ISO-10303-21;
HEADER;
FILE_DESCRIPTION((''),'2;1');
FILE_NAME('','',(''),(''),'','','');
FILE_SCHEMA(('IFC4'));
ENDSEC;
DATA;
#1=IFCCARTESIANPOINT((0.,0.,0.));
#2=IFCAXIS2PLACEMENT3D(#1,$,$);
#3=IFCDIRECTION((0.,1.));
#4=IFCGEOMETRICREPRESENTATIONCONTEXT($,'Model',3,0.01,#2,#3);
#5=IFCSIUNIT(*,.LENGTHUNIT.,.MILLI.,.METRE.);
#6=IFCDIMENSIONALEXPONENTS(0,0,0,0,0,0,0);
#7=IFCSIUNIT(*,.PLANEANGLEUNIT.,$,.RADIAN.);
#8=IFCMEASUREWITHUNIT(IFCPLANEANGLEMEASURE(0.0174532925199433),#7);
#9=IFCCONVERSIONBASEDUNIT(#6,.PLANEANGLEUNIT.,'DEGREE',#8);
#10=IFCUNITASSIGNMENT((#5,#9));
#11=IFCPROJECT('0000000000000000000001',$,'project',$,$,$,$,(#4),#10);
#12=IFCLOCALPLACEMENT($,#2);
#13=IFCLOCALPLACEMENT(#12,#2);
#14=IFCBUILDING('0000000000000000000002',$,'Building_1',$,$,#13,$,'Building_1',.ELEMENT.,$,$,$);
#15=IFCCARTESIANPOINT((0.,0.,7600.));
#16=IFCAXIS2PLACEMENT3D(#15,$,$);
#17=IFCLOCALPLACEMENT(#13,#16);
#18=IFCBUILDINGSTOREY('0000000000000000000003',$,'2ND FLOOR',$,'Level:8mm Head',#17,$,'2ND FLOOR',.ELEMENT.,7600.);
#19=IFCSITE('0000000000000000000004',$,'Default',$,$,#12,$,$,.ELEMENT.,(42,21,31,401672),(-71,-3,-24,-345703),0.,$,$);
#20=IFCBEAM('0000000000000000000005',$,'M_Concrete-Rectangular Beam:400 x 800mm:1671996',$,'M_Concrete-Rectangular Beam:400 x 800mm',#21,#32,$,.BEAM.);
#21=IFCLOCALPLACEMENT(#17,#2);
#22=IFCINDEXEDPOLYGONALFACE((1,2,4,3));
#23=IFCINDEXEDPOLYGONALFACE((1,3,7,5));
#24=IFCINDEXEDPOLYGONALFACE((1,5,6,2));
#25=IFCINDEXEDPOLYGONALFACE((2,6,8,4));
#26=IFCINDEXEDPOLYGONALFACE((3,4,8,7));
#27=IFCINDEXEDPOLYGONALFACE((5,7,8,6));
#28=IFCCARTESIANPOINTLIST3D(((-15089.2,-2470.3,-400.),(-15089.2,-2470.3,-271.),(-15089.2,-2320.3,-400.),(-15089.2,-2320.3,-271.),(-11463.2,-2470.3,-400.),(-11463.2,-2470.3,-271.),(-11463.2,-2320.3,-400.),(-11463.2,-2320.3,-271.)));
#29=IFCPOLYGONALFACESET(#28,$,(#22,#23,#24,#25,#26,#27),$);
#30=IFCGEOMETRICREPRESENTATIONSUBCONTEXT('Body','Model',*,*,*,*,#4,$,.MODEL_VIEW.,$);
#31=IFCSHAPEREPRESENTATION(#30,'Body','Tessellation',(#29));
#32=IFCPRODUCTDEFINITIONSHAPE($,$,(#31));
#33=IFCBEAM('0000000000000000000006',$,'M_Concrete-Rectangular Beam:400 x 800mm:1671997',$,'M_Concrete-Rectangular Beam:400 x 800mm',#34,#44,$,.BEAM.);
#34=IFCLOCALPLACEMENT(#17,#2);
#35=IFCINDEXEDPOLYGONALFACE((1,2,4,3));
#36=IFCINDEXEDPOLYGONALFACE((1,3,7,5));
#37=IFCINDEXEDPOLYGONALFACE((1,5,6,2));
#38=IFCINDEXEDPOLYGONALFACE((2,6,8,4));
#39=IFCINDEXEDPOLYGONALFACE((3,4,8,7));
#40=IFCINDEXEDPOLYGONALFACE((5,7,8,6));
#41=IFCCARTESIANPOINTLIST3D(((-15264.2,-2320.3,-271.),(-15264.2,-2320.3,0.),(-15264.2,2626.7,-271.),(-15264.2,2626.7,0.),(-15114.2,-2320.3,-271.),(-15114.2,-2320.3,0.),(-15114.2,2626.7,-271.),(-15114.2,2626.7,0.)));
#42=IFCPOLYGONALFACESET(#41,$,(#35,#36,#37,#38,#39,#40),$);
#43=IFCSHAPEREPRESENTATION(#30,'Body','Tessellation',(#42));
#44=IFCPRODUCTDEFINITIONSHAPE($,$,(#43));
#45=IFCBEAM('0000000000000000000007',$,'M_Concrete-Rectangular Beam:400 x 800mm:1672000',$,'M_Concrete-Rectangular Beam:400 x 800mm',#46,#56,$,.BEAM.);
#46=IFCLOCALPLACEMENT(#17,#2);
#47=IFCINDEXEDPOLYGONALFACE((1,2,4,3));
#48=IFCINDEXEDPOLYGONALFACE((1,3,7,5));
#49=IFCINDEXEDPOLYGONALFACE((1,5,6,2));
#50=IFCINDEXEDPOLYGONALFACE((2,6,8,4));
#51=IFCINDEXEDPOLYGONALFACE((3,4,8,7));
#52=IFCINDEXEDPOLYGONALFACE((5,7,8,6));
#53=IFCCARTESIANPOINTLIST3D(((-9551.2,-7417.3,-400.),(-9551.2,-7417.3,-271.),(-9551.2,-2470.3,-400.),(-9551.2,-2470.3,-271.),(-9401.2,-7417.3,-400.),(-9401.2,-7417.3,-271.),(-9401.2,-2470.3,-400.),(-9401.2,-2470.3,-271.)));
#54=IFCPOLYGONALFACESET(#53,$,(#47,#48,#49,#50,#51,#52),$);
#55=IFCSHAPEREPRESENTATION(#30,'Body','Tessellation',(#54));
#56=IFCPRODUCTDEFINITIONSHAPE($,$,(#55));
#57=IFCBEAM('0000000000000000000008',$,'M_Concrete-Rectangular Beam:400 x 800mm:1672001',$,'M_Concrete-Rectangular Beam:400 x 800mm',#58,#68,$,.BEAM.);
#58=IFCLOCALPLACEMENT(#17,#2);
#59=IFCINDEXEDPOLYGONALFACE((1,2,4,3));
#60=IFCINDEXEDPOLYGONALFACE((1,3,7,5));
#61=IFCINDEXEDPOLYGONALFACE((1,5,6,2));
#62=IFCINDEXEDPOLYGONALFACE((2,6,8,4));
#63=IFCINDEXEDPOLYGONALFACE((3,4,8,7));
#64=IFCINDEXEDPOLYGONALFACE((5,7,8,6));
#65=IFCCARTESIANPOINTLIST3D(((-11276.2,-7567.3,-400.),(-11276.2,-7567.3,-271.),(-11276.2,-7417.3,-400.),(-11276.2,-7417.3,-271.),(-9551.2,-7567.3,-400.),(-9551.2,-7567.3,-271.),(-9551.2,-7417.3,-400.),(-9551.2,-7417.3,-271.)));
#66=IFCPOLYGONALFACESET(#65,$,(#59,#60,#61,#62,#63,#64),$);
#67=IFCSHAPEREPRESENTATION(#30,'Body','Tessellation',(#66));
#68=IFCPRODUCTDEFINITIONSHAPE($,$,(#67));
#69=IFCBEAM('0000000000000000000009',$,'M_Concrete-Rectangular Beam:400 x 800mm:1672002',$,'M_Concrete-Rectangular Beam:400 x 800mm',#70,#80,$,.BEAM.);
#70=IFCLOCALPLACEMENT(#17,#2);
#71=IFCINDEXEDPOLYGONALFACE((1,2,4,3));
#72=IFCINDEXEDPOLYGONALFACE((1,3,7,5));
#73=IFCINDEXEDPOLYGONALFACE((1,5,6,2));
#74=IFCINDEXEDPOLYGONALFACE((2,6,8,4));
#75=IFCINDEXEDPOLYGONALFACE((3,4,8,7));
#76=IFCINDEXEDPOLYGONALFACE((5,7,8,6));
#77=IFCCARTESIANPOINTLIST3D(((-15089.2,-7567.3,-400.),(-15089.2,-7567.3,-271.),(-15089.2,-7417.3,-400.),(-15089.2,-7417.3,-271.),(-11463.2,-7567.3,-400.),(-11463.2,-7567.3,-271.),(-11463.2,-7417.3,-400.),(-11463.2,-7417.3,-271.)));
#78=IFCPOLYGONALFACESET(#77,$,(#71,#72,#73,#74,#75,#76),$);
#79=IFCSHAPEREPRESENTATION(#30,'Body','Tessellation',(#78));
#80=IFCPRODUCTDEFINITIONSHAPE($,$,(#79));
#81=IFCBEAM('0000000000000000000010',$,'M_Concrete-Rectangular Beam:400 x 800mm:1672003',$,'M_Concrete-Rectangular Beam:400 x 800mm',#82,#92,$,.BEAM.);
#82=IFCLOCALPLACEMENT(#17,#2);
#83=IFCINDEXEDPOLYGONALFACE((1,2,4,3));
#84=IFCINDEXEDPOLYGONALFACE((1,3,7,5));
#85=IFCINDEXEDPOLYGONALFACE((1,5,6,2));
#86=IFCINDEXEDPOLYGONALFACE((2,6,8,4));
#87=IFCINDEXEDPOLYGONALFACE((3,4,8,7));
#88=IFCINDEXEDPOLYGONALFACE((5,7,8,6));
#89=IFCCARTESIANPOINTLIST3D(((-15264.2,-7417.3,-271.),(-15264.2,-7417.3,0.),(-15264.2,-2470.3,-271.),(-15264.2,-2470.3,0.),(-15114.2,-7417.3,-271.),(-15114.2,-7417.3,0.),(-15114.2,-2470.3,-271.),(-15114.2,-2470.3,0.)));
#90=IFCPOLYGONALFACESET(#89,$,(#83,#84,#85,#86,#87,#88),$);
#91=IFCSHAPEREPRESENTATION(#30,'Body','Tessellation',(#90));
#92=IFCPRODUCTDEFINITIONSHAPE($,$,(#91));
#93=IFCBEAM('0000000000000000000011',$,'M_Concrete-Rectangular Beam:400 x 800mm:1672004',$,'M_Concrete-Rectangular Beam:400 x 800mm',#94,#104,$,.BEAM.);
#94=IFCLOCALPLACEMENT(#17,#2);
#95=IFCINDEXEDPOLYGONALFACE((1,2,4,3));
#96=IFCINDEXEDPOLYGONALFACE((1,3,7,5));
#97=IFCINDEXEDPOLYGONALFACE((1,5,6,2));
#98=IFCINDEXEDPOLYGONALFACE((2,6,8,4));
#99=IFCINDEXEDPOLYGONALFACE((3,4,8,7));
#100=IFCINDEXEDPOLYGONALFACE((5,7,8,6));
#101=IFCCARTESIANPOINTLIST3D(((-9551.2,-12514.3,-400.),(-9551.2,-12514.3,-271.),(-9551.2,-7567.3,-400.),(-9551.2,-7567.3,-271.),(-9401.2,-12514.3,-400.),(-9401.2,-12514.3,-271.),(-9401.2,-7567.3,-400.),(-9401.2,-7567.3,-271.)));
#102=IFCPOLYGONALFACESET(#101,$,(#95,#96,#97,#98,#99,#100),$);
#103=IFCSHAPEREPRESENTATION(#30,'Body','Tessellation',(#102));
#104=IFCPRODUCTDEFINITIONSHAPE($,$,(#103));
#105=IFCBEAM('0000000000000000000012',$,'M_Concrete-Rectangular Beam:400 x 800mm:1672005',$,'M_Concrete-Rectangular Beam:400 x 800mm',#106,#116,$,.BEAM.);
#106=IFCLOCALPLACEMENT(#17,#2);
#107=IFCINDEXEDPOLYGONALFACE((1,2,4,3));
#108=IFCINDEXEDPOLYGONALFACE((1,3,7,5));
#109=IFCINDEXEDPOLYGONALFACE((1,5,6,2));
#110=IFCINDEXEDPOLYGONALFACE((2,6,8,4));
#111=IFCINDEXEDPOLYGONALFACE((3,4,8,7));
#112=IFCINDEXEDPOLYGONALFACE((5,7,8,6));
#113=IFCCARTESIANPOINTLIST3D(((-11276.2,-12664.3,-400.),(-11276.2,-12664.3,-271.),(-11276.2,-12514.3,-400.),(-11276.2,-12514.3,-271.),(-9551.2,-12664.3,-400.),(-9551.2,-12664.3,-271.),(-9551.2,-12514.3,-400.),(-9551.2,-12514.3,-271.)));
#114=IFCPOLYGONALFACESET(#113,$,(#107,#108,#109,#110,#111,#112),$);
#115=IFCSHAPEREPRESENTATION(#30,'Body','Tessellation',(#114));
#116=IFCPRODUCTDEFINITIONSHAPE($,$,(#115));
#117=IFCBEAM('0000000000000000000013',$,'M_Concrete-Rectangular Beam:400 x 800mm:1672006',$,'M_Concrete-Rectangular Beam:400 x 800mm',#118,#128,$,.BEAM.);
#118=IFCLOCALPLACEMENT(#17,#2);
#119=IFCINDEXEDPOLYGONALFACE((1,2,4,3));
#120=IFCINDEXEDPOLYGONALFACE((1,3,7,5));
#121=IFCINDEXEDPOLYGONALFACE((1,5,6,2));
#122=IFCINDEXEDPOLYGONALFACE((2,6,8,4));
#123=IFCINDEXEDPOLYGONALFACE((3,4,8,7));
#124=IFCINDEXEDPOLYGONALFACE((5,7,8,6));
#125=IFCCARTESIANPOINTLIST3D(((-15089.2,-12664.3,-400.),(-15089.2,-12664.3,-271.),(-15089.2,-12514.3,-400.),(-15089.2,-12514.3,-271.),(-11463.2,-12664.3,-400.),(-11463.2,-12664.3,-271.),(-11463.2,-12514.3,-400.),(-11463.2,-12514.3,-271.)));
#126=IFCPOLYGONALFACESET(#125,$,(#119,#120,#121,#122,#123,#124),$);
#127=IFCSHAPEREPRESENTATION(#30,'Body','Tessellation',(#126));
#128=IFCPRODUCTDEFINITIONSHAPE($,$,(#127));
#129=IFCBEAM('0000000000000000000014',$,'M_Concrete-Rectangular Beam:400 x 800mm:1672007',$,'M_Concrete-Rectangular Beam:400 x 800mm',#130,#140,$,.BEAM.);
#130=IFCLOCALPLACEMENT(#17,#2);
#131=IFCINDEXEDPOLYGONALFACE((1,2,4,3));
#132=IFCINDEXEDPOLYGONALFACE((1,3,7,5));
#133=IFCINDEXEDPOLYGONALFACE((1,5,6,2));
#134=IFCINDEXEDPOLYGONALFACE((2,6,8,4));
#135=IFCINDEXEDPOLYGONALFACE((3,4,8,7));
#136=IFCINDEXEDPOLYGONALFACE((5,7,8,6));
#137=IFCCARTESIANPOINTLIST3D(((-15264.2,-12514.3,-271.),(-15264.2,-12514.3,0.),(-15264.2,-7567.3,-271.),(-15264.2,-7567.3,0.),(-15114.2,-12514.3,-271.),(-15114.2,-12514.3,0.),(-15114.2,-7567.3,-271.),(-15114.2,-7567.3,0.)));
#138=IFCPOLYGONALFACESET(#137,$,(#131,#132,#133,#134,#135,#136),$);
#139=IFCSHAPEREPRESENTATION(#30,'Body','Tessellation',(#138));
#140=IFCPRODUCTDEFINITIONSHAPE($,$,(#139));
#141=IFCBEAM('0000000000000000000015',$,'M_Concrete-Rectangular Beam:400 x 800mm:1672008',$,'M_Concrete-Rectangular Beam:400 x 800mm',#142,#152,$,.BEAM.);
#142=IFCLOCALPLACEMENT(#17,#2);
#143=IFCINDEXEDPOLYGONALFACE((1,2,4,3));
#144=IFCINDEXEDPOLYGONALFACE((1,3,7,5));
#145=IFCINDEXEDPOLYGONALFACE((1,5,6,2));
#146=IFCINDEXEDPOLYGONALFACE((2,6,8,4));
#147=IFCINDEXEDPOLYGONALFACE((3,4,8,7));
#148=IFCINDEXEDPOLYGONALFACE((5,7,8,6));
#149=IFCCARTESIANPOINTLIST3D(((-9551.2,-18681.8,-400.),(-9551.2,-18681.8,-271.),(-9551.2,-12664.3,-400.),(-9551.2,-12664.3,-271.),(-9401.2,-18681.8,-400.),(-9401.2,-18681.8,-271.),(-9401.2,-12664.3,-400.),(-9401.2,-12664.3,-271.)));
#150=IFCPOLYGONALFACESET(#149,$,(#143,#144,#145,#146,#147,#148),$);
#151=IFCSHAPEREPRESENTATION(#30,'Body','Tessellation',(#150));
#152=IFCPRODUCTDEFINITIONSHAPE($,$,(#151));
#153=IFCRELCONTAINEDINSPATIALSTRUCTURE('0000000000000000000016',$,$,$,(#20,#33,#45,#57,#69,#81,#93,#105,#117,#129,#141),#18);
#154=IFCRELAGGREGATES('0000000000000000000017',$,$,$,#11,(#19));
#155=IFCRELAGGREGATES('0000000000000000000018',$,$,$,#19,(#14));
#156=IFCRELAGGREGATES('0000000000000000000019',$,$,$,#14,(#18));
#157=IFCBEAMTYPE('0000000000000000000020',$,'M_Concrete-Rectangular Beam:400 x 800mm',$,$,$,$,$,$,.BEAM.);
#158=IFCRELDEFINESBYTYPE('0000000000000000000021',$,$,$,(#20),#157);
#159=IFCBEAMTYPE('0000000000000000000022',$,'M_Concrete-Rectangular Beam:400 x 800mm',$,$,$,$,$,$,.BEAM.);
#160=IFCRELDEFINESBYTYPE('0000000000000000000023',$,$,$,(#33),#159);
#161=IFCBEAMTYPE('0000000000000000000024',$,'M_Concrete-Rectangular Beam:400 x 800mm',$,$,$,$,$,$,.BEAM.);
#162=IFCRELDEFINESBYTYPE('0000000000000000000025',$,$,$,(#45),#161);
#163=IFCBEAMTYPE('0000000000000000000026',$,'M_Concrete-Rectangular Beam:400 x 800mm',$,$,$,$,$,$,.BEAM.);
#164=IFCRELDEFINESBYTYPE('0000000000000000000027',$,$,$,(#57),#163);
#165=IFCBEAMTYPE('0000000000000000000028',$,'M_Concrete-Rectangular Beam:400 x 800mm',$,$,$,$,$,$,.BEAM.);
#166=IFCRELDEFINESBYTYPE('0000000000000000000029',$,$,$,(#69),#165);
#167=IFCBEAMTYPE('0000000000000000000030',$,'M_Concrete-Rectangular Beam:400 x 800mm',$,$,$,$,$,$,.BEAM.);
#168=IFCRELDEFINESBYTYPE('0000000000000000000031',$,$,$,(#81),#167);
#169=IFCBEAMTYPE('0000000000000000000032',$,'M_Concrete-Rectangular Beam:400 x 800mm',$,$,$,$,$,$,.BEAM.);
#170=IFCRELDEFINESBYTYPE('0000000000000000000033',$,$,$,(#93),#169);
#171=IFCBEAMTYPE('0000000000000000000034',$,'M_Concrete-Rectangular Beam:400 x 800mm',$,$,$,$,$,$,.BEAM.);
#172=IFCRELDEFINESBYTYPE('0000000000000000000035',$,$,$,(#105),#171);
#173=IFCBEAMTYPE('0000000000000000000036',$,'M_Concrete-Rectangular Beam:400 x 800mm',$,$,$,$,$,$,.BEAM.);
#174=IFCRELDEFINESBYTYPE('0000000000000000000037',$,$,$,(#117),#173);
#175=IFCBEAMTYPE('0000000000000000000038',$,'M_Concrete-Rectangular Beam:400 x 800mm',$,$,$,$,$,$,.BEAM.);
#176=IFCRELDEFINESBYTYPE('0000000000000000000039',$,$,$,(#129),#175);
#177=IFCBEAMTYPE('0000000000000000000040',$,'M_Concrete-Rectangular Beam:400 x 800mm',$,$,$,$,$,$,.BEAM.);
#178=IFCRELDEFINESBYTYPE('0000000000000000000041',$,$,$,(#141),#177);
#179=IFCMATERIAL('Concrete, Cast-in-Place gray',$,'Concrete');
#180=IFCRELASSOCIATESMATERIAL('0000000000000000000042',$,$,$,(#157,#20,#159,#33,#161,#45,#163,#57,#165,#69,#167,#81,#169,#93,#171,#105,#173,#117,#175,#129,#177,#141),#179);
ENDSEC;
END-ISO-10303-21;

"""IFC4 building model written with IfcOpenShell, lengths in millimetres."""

from ifc_helpers import new_model, entity, si_unit, converted_unit, direction, frame, origin, place, context, subcontext, project, spatial, indexed_curve, outline, extrude, source, transform, mapped, material, type_object, type_shapes, element, save


model = new_model("IFC4")

# Units and contexts
model_context = context("Model", 3, precision=0.01, world=origin(), true_north=direction((0.0, 1.0)))
body_context = subcontext(model_context, "Body", "Model", "MODEL_VIEW")
ifc_project = project(units=[si_unit("LENGTHUNIT", "METRE", prefix="MILLI"), converted_unit("PLANEANGLEUNIT", "DEGREE", entity("IfcPlaneAngleMeasure", 0.0174532925199433), si_unit("PLANEANGLEUNIT", "RADIAN"), dimensions=[0, 0, 0, 0, 0, 0, 0])], contexts=[model_context])

# Site, building, storey
site_placement = place(None, origin())
site = spatial("IfcSite", under=ifc_project, at=site_placement, Name="Default", CompositionType="ELEMENT", RefLatitude=(42, 21, 31, 401672), RefLongitude=(-71, -3, -24, -345703), RefElevation=0.0)
building_placement = place(site_placement, origin())
building = spatial("IfcBuilding", under=site, at=building_placement, Name="Building_1", LongName="Building_1", CompositionType="ELEMENT")
storey_placement = place(building_placement, frame((0.0, 0.0, 7600.0)))
storey = spatial("IfcBuildingStorey", under=building, at=storey_placement, Name="2ND FLOOR", ObjectType="Level:8mm Head", LongName="2ND FLOOR", CompositionType="ELEMENT", Elevation=7600.0)

# Beams
ifc_material = material(Name="Concrete, Cast-in-Place gray", Category="Concrete")
beam_type_1 = type_object("IfcBeamType", Name="M_Concrete-Rectangular Beam:400 x 800mm", PredefinedType="BEAM", material=ifc_material)
shared_shape_1 = source(origin(), body_context, "Body", "SweptSolid", [
    extrude(outline(indexed_curve([(-64.5, -75.0), (64.5, -75.0), (64.5, 75.0), (-64.5, 75.0), (-64.5, -75.0)], self_intersect=False)), frame((-11463.2, -2395.3, 7264.5), z_axis=(-1.0, 0.0, 0.0), x_axis=(0.0, 0.0, -1.0)), (0.0, 0.0, 1.0), 3626.0),
])
type_shapes(beam_type_1, [shared_shape_1])
beam_1_placement = place(storey_placement, frame((0.0, 0.0, -7600.0)))
element("IfcBeam", 1, at=beam_1_placement, inside=storey, type_object=beam_type_1, material=ifc_material, Name="M_Concrete-Rectangular Beam:400 x 800mm:1671996", ObjectType="M_Concrete-Rectangular Beam:400 x 800mm", PredefinedType="BEAM", context=body_context, shape_type="MappedRepresentation", body=[
    mapped(shared_shape_1, transform((0.0, 0.0, 0.0), scale=1.0)),
])
beam_type_2 = type_object("IfcBeamType", Name="M_Concrete-Rectangular Beam:400 x 800mm", PredefinedType="BEAM", material=ifc_material)
shared_shape_2 = source(origin(), body_context, "Body", "SweptSolid", [
    extrude(outline(indexed_curve([(-75.0, -135.5), (75.0, -135.5), (75.0, 135.5), (-75.0, 135.5), (-75.0, -135.5)], self_intersect=False)), frame((-15189.2, -2320.3, 7464.5), z_axis=(0.0, 1.0, 0.0), x_axis=(-1.0, 0.0, 0.0)), (0.0, 0.0, 1.0), 4947.0),
])
type_shapes(beam_type_2, [shared_shape_2])
beam_2_placement = place(storey_placement, frame((0.0, 0.0, -7600.0)))
element("IfcBeam", 2, at=beam_2_placement, inside=storey, type_object=beam_type_2, material=ifc_material, Name="M_Concrete-Rectangular Beam:400 x 800mm:1671997", ObjectType="M_Concrete-Rectangular Beam:400 x 800mm", PredefinedType="BEAM", context=body_context, shape_type="MappedRepresentation", body=[
    mapped(shared_shape_2, transform((0.0, 0.0, 0.0), scale=1.0)),
])
beam_type_3 = type_object("IfcBeamType", Name="M_Concrete-Rectangular Beam:400 x 800mm", PredefinedType="BEAM", material=ifc_material)
shared_shape_3 = source(origin(), body_context, "Body", "SweptSolid", [
    extrude(outline(indexed_curve([(-75.0, -64.5), (75.0, -64.5), (75.0, 64.5), (-75.0, 64.5), (-75.0, -64.5)], self_intersect=False)), frame((-9476.2, -2470.3, 7264.5), z_axis=(0.0, -1.0, 0.0), x_axis=(-1.0, 0.0, 0.0)), (0.0, 0.0, 1.0), 4947.0),
])
type_shapes(beam_type_3, [shared_shape_3])
beam_3_placement = place(storey_placement, frame((0.0, 0.0, -7600.0)))
element("IfcBeam", 3, at=beam_3_placement, inside=storey, type_object=beam_type_3, material=ifc_material, Name="M_Concrete-Rectangular Beam:400 x 800mm:1672000", ObjectType="M_Concrete-Rectangular Beam:400 x 800mm", PredefinedType="BEAM", context=body_context, shape_type="MappedRepresentation", body=[
    mapped(shared_shape_3, transform((0.0, 0.0, 0.0), scale=1.0)),
])
beam_type_4 = type_object("IfcBeamType", Name="M_Concrete-Rectangular Beam:400 x 800mm", PredefinedType="BEAM", material=ifc_material)
shared_shape_4 = source(origin(), body_context, "Body", "SweptSolid", [
    extrude(outline(indexed_curve([(-64.5, -75.0), (64.5, -75.0), (64.5, 75.0), (-64.5, 75.0), (-64.5, -75.0)], self_intersect=False)), frame((-9551.2, -7492.3, 7264.5), z_axis=(-1.0, 0.0, 0.0), x_axis=(0.0, 0.0, -1.0)), (0.0, 0.0, 1.0), 1725.0),
])
type_shapes(beam_type_4, [shared_shape_4])
beam_4_placement = place(storey_placement, frame((0.0, 0.0, -7600.0)))
element("IfcBeam", 4, at=beam_4_placement, inside=storey, type_object=beam_type_4, material=ifc_material, Name="M_Concrete-Rectangular Beam:400 x 800mm:1672001", ObjectType="M_Concrete-Rectangular Beam:400 x 800mm", PredefinedType="BEAM", context=body_context, shape_type="MappedRepresentation", body=[
    mapped(shared_shape_4, transform((0.0, 0.0, 0.0), scale=1.0)),
])
beam_type_5 = type_object("IfcBeamType", Name="M_Concrete-Rectangular Beam:400 x 800mm", PredefinedType="BEAM", material=ifc_material)
shared_shape_5 = source(origin(), body_context, "Body", "SweptSolid", [
    extrude(outline(indexed_curve([(-64.5, -75.0), (64.5, -75.0), (64.5, 75.0), (-64.5, 75.0), (-64.5, -75.0)], self_intersect=False)), frame((-11463.2, -7492.3, 7264.5), z_axis=(-1.0, 0.0, 0.0), x_axis=(0.0, 0.0, -1.0)), (0.0, 0.0, 1.0), 3626.0),
])
type_shapes(beam_type_5, [shared_shape_5])
beam_5_placement = place(storey_placement, frame((0.0, 0.0, -7600.0)))
element("IfcBeam", 5, at=beam_5_placement, inside=storey, type_object=beam_type_5, material=ifc_material, Name="M_Concrete-Rectangular Beam:400 x 800mm:1672002", ObjectType="M_Concrete-Rectangular Beam:400 x 800mm", PredefinedType="BEAM", context=body_context, shape_type="MappedRepresentation", body=[
    mapped(shared_shape_5, transform((0.0, 0.0, 0.0), scale=1.0)),
])
beam_type_6 = type_object("IfcBeamType", Name="M_Concrete-Rectangular Beam:400 x 800mm", PredefinedType="BEAM", material=ifc_material)
shared_shape_6 = source(origin(), body_context, "Body", "SweptSolid", [
    extrude(outline(indexed_curve([(-75.0, -135.5), (75.0, -135.5), (75.0, 135.5), (-75.0, 135.5), (-75.0, -135.5)], self_intersect=False)), frame((-15189.2, -7417.3, 7464.5), z_axis=(0.0, 1.0, 0.0), x_axis=(-1.0, 0.0, 0.0)), (0.0, 0.0, 1.0), 4947.0),
])
type_shapes(beam_type_6, [shared_shape_6])
beam_6_placement = place(storey_placement, frame((0.0, 0.0, -7600.0)))
element("IfcBeam", 6, at=beam_6_placement, inside=storey, type_object=beam_type_6, material=ifc_material, Name="M_Concrete-Rectangular Beam:400 x 800mm:1672003", ObjectType="M_Concrete-Rectangular Beam:400 x 800mm", PredefinedType="BEAM", context=body_context, shape_type="MappedRepresentation", body=[
    mapped(shared_shape_6, transform((0.0, 0.0, 0.0), scale=1.0)),
])
beam_type_7 = type_object("IfcBeamType", Name="M_Concrete-Rectangular Beam:400 x 800mm", PredefinedType="BEAM", material=ifc_material)
shared_shape_7 = source(origin(), body_context, "Body", "SweptSolid", [
    extrude(outline(indexed_curve([(-75.0, -64.5), (75.0, -64.5), (75.0, 64.5), (-75.0, 64.5), (-75.0, -64.5)], self_intersect=False)), frame((-9476.2, -7567.3, 7264.5), z_axis=(0.0, -1.0, 0.0), x_axis=(-1.0, 0.0, 0.0)), (0.0, 0.0, 1.0), 4947.0),
])
type_shapes(beam_type_7, [shared_shape_7])
beam_7_placement = place(storey_placement, frame((0.0, 0.0, -7600.0)))
element("IfcBeam", 7, at=beam_7_placement, inside=storey, type_object=beam_type_7, material=ifc_material, Name="M_Concrete-Rectangular Beam:400 x 800mm:1672004", ObjectType="M_Concrete-Rectangular Beam:400 x 800mm", PredefinedType="BEAM", context=body_context, shape_type="MappedRepresentation", body=[
    mapped(shared_shape_7, transform((0.0, 0.0, 0.0), scale=1.0)),
])
beam_type_8 = type_object("IfcBeamType", Name="M_Concrete-Rectangular Beam:400 x 800mm", PredefinedType="BEAM", material=ifc_material)
shared_shape_8 = source(origin(), body_context, "Body", "SweptSolid", [
    extrude(outline(indexed_curve([(-64.5, -75.0), (64.5, -75.0), (64.5, 75.0), (-64.5, 75.0), (-64.5, -75.0)], self_intersect=False)), frame((-9551.2, -12589.3, 7264.5), z_axis=(-1.0, 0.0, 0.0), x_axis=(0.0, 0.0, -1.0)), (0.0, 0.0, 1.0), 1725.0),
])
type_shapes(beam_type_8, [shared_shape_8])
beam_8_placement = place(storey_placement, frame((0.0, 0.0, -7600.0)))
element("IfcBeam", 8, at=beam_8_placement, inside=storey, type_object=beam_type_8, material=ifc_material, Name="M_Concrete-Rectangular Beam:400 x 800mm:1672005", ObjectType="M_Concrete-Rectangular Beam:400 x 800mm", PredefinedType="BEAM", context=body_context, shape_type="MappedRepresentation", body=[
    mapped(shared_shape_8, transform((0.0, 0.0, 0.0), scale=1.0)),
])
beam_type_9 = type_object("IfcBeamType", Name="M_Concrete-Rectangular Beam:400 x 800mm", PredefinedType="BEAM", material=ifc_material)
shared_shape_9 = source(origin(), body_context, "Body", "SweptSolid", [
    extrude(outline(indexed_curve([(-64.5, -75.0), (64.5, -75.0), (64.5, 75.0), (-64.5, 75.0), (-64.5, -75.0)], self_intersect=False)), frame((-11463.2, -12589.3, 7264.5), z_axis=(-1.0, 0.0, 0.0), x_axis=(0.0, 0.0, -1.0)), (0.0, 0.0, 1.0), 3626.0),
])
type_shapes(beam_type_9, [shared_shape_9])
beam_9_placement = place(storey_placement, frame((0.0, 0.0, -7600.0)))
element("IfcBeam", 9, at=beam_9_placement, inside=storey, type_object=beam_type_9, material=ifc_material, Name="M_Concrete-Rectangular Beam:400 x 800mm:1672006", ObjectType="M_Concrete-Rectangular Beam:400 x 800mm", PredefinedType="BEAM", context=body_context, shape_type="MappedRepresentation", body=[
    mapped(shared_shape_9, transform((0.0, 0.0, 0.0), scale=1.0)),
])
beam_type_10 = type_object("IfcBeamType", Name="M_Concrete-Rectangular Beam:400 x 800mm", PredefinedType="BEAM", material=ifc_material)
shared_shape_10 = source(origin(), body_context, "Body", "SweptSolid", [
    extrude(outline(indexed_curve([(-75.0, -135.5), (75.0, -135.5), (75.0, 135.5), (-75.0, 135.5), (-75.0, -135.5)], self_intersect=False)), frame((-15189.2, -12514.3, 7464.5), z_axis=(0.0, 1.0, 0.0), x_axis=(-1.0, 0.0, 0.0)), (0.0, 0.0, 1.0), 4947.0),
])
type_shapes(beam_type_10, [shared_shape_10])
beam_10_placement = place(storey_placement, frame((0.0, 0.0, -7600.0)))
element("IfcBeam", 10, at=beam_10_placement, inside=storey, type_object=beam_type_10, material=ifc_material, Name="M_Concrete-Rectangular Beam:400 x 800mm:1672007", ObjectType="M_Concrete-Rectangular Beam:400 x 800mm", PredefinedType="BEAM", context=body_context, shape_type="MappedRepresentation", body=[
    mapped(shared_shape_10, transform((0.0, 0.0, 0.0), scale=1.0)),
])
beam_type_11 = type_object("IfcBeamType", Name="M_Concrete-Rectangular Beam:400 x 800mm", PredefinedType="BEAM", material=ifc_material)
shared_shape_11 = source(origin(), body_context, "Body", "SweptSolid", [
    extrude(outline(indexed_curve([(-75.0, -64.5), (75.0, -64.5), (75.0, 64.5), (-75.0, 64.5), (-75.0, -64.5)], self_intersect=False)), frame((-9476.2, -12664.3, 7264.5), z_axis=(0.0, -1.0, 0.0), x_axis=(-1.0, 0.0, 0.0)), (0.0, 0.0, 1.0), 6017.5),
])
type_shapes(beam_type_11, [shared_shape_11])
beam_11_placement = place(storey_placement, frame((0.0, 0.0, -7600.0)))
element("IfcBeam", 11, at=beam_11_placement, inside=storey, type_object=beam_type_11, material=ifc_material, Name="M_Concrete-Rectangular Beam:400 x 800mm:1672008", ObjectType="M_Concrete-Rectangular Beam:400 x 800mm", PredefinedType="BEAM", context=body_context, shape_type="MappedRepresentation", body=[
    mapped(shared_shape_11, transform((0.0, 0.0, 0.0), scale=1.0)),
])

save(model, "model.ifc")
